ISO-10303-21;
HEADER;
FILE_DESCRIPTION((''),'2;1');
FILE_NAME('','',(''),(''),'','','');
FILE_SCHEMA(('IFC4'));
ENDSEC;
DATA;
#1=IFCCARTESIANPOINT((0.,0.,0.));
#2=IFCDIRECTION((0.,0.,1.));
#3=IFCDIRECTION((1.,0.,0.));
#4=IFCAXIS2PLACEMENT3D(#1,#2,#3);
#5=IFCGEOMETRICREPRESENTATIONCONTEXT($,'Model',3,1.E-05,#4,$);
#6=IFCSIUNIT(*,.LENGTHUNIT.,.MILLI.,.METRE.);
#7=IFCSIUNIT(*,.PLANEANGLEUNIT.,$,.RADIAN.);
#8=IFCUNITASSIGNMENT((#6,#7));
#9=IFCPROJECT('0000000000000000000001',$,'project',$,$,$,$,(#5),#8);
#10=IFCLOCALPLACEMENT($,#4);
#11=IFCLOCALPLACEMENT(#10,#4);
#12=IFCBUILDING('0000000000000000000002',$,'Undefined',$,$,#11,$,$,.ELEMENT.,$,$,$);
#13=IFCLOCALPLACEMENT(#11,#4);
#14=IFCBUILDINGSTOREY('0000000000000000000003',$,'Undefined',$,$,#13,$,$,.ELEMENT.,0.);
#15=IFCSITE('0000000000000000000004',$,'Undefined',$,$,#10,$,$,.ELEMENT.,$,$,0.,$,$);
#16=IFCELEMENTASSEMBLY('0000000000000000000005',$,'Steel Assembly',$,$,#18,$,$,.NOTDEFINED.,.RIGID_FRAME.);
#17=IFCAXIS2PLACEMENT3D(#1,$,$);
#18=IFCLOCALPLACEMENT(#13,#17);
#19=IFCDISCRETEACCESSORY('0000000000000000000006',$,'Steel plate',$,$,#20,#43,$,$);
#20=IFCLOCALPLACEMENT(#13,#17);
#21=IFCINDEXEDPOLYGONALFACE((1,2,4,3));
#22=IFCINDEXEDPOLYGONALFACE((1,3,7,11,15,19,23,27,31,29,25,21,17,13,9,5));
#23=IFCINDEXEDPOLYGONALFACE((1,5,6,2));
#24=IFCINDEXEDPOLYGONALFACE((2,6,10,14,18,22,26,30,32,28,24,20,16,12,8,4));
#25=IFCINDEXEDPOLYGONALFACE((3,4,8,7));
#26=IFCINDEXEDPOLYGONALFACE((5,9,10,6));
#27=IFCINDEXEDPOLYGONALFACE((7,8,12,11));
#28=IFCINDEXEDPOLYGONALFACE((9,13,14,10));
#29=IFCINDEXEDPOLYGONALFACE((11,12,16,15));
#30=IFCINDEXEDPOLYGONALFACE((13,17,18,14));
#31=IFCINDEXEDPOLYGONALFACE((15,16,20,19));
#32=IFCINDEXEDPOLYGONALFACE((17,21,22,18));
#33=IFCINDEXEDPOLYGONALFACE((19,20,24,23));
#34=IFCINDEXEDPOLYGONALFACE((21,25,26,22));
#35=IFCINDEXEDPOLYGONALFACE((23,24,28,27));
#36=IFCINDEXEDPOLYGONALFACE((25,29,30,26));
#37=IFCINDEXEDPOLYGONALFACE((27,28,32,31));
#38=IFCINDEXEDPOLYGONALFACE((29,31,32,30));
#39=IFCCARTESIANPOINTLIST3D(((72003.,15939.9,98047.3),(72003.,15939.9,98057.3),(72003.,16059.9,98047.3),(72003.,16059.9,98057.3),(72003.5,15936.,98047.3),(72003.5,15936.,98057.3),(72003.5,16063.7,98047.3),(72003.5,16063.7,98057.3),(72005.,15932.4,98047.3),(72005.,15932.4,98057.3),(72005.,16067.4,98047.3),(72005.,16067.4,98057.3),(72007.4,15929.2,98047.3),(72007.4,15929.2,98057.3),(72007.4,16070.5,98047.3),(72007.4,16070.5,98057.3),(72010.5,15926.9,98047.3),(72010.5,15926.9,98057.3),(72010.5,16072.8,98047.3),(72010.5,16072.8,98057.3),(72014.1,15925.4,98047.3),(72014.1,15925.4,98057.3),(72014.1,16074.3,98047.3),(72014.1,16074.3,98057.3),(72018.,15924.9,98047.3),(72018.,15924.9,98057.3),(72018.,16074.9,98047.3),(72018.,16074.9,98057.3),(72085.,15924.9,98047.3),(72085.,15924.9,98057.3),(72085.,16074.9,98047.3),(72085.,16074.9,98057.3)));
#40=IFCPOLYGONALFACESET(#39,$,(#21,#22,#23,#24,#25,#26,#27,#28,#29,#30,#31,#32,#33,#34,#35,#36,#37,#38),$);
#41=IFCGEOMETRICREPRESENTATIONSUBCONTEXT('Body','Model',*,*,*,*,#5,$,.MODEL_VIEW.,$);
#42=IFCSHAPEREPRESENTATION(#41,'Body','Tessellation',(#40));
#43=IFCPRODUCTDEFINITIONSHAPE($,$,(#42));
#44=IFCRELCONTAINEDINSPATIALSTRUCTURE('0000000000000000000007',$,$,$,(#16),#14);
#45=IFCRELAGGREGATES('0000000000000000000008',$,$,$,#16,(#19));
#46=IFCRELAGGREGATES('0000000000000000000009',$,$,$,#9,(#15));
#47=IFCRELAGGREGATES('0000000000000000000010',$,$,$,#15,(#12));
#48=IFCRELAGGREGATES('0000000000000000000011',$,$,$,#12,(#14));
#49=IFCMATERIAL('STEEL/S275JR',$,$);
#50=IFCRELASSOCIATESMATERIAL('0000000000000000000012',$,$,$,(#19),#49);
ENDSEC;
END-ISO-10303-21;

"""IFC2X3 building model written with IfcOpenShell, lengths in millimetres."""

from ifc_helpers import new_model, si_unit, frame, frame_2d, origin_with_axes, place, context, subcontext, project, spatial, polyline, circle_curve, parameter, trimmed, segment, composite_curve, outline, extrude, material, element, aggregate, save


model = new_model("IFC2X3")

# Units and contexts
model_context = context("Model", 3, precision=1e-05, world=origin_with_axes())
body_context = subcontext(model_context, "Body", "Model", "MODEL_VIEW")
ifc_project = project(units=[si_unit("LENGTHUNIT", "METRE", prefix="MILLI"), si_unit("PLANEANGLEUNIT", "RADIAN")], contexts=[model_context])

# Site, building, storey
site_placement = place(None, origin_with_axes())
site = spatial("IfcSite", under=ifc_project, at=site_placement, Name="Undefined", CompositionType="ELEMENT", RefElevation=0.0)
building_placement = place(site_placement, origin_with_axes())
building = spatial("IfcBuilding", under=site, at=building_placement, Name="Undefined", CompositionType="ELEMENT")
storey_placement = place(building_placement, origin_with_axes())
storey = spatial("IfcBuildingStorey", under=building, at=storey_placement, Name="Undefined", CompositionType="ELEMENT", Elevation=0.0)

# Shared definitions
ifc_material_1 = material(Name="STEEL/S275JR")

# Element assembly, discrete accessory
assembly_1_placement = place(storey_placement, origin_with_axes())
assembly_1 = element("IfcElementAssembly", 1, at=assembly_1_placement, inside=storey, Name="Steel Assembly", AssemblyPlace="NOTDEFINED", PredefinedType="RIGID_FRAME")
discrete_accessory_1_placement = place(assembly_1_placement, frame((72003.0, 16074.9, 98052.3), z_axis=(0.0, 0.0, -1.0), x_axis=(1.0, 0.0, 0.0)))
discrete_accessory_1 = element("IfcDiscreteAccessory", 2, at=discrete_accessory_1_placement, material=ifc_material_1, Name="Steel plate", context=body_context, shape_type="SweptSolid", body=[
    extrude(outline(composite_curve([segment(trimmed(circle_curve(frame_2d((15.0, 15.0), x_axis=(-1.0, 0.0)), 15.0), [parameter(0.0)], [parameter(1.570796)], True, "PARAMETER"), True, "CONTINUOUS"), segment(polyline([(15.0, 0.0), (82.0, 0.0), (82.0, 150.0), (15.0, 150.0)]), True, "CONTINUOUS"), segment(trimmed(circle_curve(frame_2d((15.0, 135.0), x_axis=(0.0, 1.0)), 15.0), [parameter(0.0)], [parameter(1.570796)], True, "PARAMETER"), True, "CONTINUOUS"), segment(polyline([(0.0, 135.0), (0.0, 15.0)]), True, "DISCONTINUOUS")], self_intersect=False)), frame((0.0, 0.0, -5.0), z_axis=(0.0, 0.0, 1.0), x_axis=(1.0, 0.0, 0.0)), (0.0, 0.0, 1.0), 10.0),
])
aggregate(assembly_1, [discrete_accessory_1])

save(model, "model.ifc")
